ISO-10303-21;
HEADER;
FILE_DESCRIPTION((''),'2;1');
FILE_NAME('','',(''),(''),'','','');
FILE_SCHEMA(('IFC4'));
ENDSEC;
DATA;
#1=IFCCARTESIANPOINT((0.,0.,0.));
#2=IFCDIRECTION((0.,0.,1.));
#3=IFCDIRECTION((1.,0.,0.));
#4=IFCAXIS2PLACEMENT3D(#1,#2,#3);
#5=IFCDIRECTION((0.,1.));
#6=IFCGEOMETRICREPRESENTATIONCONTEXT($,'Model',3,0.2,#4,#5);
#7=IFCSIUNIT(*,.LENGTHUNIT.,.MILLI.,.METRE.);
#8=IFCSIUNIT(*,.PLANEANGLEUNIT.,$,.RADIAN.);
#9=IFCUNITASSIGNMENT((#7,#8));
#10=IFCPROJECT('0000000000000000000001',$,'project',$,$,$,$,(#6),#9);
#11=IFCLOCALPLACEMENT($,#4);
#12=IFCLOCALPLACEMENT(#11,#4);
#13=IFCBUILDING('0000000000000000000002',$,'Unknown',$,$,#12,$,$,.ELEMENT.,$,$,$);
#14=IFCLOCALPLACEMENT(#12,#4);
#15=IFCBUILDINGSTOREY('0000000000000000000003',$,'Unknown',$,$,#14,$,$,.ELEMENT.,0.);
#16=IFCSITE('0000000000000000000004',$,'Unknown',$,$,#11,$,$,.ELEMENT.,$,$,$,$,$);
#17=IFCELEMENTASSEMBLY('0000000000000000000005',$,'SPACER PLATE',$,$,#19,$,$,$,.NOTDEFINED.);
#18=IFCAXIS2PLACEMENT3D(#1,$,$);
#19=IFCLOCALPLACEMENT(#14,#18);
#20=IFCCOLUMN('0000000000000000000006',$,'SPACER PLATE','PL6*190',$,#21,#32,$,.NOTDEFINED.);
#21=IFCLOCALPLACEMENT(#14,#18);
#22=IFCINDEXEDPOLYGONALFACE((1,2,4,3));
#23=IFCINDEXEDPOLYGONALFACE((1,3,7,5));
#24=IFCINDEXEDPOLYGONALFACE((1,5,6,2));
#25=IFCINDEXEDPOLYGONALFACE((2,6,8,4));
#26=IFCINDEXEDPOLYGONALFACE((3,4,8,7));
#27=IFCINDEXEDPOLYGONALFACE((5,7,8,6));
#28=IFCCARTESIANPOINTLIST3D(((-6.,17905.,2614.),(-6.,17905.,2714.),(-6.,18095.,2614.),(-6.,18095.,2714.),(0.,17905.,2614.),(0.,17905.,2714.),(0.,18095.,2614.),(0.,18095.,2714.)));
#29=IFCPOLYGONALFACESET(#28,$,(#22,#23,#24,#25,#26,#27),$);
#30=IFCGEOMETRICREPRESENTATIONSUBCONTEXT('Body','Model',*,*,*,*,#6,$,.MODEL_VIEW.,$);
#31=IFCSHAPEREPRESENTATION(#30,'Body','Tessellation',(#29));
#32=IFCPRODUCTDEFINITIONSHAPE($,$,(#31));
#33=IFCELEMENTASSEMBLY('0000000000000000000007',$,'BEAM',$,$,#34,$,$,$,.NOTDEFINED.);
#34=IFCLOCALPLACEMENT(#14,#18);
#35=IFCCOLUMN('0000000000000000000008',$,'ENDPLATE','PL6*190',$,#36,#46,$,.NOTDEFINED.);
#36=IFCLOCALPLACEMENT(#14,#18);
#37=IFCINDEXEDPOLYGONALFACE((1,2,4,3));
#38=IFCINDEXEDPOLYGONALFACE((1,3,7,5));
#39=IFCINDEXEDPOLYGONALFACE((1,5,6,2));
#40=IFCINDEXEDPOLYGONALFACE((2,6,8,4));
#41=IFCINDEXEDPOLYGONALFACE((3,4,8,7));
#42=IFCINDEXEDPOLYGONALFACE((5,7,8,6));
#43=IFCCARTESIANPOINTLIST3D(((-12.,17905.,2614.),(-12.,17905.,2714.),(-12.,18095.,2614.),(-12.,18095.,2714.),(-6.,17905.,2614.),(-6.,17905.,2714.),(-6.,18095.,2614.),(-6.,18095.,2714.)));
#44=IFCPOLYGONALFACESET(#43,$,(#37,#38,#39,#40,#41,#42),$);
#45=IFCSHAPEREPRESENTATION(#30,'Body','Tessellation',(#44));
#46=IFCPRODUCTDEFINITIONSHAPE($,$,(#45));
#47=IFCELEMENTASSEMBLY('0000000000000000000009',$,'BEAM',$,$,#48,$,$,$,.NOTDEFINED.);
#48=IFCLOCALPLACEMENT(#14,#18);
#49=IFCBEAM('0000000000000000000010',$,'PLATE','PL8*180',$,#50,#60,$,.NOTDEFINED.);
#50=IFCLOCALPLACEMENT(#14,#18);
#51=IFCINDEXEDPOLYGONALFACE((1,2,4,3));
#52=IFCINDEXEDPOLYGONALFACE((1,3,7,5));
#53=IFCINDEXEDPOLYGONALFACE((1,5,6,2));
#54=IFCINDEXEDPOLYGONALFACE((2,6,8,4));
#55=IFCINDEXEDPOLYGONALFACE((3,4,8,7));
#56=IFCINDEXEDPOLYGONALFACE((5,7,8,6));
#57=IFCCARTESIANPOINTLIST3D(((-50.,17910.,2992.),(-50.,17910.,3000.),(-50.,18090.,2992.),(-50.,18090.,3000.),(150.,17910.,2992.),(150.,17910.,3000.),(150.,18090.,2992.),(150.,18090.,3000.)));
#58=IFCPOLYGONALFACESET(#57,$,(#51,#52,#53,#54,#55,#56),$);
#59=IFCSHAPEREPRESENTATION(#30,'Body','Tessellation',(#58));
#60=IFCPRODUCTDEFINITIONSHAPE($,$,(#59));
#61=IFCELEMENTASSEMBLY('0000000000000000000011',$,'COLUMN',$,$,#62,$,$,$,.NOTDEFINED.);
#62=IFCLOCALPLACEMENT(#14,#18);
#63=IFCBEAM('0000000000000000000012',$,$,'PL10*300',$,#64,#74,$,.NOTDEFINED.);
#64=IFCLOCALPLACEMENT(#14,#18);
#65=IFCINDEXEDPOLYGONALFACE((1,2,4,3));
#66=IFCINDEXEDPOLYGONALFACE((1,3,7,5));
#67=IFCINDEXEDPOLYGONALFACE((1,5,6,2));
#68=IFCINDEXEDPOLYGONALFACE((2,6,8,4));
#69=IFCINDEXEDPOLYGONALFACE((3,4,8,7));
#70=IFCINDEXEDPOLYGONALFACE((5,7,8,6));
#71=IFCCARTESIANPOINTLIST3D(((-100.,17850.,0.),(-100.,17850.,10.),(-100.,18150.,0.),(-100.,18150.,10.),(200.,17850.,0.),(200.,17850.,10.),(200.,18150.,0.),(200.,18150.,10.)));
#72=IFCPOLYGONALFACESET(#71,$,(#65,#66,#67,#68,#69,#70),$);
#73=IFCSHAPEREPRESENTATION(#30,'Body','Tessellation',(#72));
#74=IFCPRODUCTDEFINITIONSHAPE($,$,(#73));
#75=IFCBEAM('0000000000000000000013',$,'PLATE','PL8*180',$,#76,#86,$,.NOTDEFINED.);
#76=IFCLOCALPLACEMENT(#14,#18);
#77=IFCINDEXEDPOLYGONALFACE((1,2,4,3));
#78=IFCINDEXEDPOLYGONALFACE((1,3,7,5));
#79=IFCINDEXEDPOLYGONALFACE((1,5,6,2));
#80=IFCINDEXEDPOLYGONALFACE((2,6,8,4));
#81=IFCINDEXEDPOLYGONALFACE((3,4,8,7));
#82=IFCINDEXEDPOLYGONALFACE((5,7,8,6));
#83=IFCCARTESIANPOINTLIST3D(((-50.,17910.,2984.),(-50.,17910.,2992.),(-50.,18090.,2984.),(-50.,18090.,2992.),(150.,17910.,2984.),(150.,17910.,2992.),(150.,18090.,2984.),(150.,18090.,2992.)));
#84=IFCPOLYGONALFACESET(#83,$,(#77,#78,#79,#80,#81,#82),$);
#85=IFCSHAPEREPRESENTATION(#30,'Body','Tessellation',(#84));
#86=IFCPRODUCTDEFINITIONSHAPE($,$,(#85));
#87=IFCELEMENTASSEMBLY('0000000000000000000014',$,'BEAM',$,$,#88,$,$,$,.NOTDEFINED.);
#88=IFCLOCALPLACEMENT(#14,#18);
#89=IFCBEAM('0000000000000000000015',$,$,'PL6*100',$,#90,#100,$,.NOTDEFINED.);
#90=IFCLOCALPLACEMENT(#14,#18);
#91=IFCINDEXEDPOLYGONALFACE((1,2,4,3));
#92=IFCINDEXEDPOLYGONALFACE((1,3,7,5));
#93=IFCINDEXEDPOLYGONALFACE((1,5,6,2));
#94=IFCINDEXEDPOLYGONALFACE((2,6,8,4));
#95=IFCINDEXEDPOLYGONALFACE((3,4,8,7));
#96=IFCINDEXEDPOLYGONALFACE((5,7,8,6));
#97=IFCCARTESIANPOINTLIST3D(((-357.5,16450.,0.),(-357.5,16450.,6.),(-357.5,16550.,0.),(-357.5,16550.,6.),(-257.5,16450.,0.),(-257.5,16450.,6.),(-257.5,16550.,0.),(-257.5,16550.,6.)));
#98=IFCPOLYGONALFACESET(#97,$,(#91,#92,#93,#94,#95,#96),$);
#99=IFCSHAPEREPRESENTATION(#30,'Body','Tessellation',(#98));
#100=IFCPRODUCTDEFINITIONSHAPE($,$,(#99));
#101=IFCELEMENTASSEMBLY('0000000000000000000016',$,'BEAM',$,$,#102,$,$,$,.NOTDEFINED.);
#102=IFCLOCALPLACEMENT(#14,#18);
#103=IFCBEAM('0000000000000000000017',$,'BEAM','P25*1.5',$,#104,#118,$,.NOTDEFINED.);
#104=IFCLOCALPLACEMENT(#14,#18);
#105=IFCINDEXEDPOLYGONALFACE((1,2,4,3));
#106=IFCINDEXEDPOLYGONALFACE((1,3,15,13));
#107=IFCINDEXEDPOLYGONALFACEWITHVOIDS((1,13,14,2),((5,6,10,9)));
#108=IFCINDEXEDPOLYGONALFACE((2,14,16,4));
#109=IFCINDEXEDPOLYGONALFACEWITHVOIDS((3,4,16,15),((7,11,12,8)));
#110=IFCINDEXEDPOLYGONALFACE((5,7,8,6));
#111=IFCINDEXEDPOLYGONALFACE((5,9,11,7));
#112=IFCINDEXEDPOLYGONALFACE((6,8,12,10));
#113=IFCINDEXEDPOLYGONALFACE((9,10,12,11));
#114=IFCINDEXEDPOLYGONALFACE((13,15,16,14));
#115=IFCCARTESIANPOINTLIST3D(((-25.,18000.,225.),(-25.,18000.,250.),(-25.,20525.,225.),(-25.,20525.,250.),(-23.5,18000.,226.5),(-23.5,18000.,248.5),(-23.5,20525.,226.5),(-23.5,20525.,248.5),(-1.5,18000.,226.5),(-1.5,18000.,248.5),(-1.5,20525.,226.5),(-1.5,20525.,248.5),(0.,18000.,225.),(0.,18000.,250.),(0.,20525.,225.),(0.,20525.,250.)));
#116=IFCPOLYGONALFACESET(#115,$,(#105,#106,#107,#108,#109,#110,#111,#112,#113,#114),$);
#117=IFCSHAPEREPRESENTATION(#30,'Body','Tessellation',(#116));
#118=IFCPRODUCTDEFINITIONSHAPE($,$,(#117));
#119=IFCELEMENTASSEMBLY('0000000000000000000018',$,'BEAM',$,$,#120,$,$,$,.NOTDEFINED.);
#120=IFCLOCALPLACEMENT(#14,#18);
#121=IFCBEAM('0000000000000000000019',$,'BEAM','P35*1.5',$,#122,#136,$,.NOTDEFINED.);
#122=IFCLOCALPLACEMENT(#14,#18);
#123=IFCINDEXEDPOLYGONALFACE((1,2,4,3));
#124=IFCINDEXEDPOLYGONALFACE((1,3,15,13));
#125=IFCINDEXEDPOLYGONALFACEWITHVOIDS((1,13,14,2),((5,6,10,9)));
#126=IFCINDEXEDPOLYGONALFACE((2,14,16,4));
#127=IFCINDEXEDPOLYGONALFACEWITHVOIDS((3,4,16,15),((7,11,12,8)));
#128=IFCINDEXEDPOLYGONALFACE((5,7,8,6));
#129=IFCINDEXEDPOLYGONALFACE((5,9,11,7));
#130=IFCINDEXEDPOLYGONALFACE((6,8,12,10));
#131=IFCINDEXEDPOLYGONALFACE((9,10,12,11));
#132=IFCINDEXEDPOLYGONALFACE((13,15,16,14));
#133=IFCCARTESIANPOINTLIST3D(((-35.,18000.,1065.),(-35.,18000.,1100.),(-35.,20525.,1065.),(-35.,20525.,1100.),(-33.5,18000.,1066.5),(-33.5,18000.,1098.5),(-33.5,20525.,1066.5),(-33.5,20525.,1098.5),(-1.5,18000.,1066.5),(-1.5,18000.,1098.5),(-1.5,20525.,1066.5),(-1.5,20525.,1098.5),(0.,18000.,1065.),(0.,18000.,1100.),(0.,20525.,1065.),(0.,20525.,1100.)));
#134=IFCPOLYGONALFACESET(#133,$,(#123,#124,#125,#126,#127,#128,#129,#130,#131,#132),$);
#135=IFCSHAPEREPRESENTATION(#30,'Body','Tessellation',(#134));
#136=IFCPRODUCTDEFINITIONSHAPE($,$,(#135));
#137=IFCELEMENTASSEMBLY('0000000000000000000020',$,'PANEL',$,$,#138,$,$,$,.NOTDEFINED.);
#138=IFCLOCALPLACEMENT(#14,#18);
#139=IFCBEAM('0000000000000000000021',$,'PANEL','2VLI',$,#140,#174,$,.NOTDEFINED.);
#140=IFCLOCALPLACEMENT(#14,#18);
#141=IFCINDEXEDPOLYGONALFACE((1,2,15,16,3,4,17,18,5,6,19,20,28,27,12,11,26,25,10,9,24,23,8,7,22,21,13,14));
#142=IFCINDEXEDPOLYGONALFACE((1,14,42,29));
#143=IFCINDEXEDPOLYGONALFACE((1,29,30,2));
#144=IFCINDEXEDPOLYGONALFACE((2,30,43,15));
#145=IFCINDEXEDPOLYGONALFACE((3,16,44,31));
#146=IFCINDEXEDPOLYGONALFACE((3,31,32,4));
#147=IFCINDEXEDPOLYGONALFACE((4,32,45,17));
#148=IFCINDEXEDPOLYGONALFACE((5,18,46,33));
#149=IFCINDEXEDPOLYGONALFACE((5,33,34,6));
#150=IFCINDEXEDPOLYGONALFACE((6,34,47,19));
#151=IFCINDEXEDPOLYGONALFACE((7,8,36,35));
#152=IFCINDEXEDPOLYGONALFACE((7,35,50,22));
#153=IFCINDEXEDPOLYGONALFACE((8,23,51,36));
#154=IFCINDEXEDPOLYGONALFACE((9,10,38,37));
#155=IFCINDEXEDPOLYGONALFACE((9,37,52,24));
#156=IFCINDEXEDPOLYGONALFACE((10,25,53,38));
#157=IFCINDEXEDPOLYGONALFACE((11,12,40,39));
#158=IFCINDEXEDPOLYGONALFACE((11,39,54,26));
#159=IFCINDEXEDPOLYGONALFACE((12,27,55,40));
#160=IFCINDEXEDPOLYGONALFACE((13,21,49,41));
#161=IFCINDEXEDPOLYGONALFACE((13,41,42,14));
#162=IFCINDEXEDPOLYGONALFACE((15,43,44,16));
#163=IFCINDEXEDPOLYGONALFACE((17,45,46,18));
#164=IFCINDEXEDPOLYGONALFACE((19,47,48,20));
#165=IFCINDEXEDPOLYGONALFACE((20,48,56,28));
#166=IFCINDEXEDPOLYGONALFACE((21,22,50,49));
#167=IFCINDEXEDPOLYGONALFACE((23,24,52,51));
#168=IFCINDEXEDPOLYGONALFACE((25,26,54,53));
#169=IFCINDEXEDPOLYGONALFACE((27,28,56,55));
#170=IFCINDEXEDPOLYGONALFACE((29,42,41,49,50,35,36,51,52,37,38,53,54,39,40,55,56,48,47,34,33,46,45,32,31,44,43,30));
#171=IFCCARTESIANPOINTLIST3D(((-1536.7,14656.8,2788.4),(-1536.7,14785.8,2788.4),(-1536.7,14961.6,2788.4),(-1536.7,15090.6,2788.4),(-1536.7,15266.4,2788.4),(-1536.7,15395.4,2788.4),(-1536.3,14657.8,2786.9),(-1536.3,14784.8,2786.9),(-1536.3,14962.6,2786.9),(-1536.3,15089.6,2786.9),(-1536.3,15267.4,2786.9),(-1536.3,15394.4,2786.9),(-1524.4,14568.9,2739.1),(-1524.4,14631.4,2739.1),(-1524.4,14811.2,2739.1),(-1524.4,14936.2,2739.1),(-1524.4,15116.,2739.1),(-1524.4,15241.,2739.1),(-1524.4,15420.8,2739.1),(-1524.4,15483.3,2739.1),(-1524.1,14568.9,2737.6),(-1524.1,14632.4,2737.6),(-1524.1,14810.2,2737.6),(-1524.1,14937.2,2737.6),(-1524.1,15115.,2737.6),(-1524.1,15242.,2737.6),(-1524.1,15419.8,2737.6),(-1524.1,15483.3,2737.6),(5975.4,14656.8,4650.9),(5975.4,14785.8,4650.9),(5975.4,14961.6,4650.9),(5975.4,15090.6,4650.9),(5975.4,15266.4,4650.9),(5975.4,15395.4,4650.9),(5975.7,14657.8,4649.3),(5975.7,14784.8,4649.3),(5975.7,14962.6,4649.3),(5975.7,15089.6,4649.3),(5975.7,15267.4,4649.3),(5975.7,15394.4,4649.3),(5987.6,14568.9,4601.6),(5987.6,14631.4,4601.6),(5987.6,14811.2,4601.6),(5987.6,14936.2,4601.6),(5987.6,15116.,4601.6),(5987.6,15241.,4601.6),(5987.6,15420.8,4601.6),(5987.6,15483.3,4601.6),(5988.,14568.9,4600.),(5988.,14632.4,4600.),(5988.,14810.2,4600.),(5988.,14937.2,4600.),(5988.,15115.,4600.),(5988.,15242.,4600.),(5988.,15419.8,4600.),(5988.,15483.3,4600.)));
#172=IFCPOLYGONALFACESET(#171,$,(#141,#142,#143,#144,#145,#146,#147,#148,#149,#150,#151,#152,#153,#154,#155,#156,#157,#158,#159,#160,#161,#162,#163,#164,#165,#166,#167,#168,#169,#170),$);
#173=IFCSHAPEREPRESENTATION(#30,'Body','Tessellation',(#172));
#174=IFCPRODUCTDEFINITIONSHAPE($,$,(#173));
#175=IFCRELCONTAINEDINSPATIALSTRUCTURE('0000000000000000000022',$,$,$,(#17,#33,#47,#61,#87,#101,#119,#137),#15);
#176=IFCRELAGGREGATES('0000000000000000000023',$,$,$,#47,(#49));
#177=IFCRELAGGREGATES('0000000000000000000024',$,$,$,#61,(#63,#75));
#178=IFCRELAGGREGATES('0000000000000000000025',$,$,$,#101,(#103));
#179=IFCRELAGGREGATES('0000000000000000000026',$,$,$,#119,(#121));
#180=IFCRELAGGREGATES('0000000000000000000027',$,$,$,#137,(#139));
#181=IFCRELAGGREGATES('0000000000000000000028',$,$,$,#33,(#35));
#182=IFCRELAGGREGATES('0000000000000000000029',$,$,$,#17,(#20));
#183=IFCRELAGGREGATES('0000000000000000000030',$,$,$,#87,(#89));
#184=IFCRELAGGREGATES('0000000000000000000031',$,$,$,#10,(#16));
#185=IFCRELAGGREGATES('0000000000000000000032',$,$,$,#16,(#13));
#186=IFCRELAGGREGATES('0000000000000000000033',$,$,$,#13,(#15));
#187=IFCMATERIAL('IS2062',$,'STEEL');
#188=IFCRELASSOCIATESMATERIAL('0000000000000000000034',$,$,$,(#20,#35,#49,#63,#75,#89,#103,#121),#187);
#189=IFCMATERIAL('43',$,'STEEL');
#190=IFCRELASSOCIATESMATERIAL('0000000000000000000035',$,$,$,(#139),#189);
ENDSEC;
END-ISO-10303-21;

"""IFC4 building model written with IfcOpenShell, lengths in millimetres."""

from ifc_helpers import new_model, si_unit, direction, frame, origin_with_axes, place, context, subcontext, project, spatial, line, indexed_curve, outline, extrude, material, element, aggregate, save


model = new_model("IFC4")

# Units and contexts
model_context = context("Model", 3, precision=0.2, world=origin_with_axes(), true_north=direction((0.0, 1.0)))
body_context = subcontext(model_context, "Body", "Model", "MODEL_VIEW")
ifc_project = project(units=[si_unit("LENGTHUNIT", "METRE", prefix="MILLI"), si_unit("PLANEANGLEUNIT", "RADIAN")], contexts=[model_context])

# Site, building, storey
site_placement = place(None, origin_with_axes())
site = spatial("IfcSite", under=ifc_project, at=site_placement, Name="Unknown", CompositionType="ELEMENT")
building_placement = place(site_placement, origin_with_axes())
building = spatial("IfcBuilding", under=site, at=building_placement, Name="Unknown", CompositionType="ELEMENT")
storey_placement = place(building_placement, origin_with_axes())
storey = spatial("IfcBuildingStorey", under=building, at=storey_placement, Name="Unknown", CompositionType="ELEMENT", Elevation=0.0)

# Element assemblies, columns
assembly_1_placement = place(storey_placement, frame((-3.0, 18000.0, 2614.0), z_axis=(-1.0, 0.0, 0.0), x_axis=(0.0, 0.0, 1.0)))
assembly_1 = element("IfcElementAssembly", 1, at=assembly_1_placement, inside=storey, Name="SPACER PLATE", PredefinedType="NOTDEFINED")
ifc_material_1 = material(Name="IS2062", Category="STEEL")
column_1_placement = place(assembly_1_placement, origin_with_axes())
column_1 = element("IfcColumn", 2, at=column_1_placement, material=ifc_material_1, Name="SPACER PLATE", Description="PL6*190", PredefinedType="NOTDEFINED", context=body_context, shape_type="SolidModel", body=[
    extrude(outline(indexed_curve([(-3.0, -95.0), (3.0, -95.0), (3.0, 95.0), (-3.0, 95.0)], segments=[line(1, 2, 3, 4, 1)])), frame((0.0, 0.0, 0.0), z_axis=(-1.0, 0.0, 0.0), x_axis=(0.0, 0.0, 1.0)), (0.0, 0.0, -1.0), 100.0),
])
assembly_2_placement = place(storey_placement, frame((-1505.9, 18000.0, 2664.0), z_axis=(0.0, -1.0, 0.0), x_axis=(1.0, 0.0, 0.0)))
assembly_2 = element("IfcElementAssembly", 3, at=assembly_2_placement, inside=storey, Name="BEAM", PredefinedType="NOTDEFINED")
column_2_placement = place(assembly_2_placement, frame((1496.9, -50.0, 0.0), z_axis=(-1.0, 0.0, 0.0), x_axis=(0.0, 1.0, 0.0)))
column_2 = element("IfcColumn", 4, at=column_2_placement, material=ifc_material_1, Name="ENDPLATE", Description="PL6*190", PredefinedType="NOTDEFINED", context=body_context, shape_type="SolidModel", body=[
    extrude(outline(indexed_curve([(-3.0, -95.0), (3.0, -95.0), (3.0, 95.0), (-3.0, 95.0)], segments=[line(1, 2, 3, 4, 1)])), frame((0.0, 0.0, 0.0), z_axis=(-1.0, 0.0, 0.0), x_axis=(0.0, 0.0, 1.0)), (0.0, 0.0, -1.0), 100.0),
])

# Element assembly, beam
assembly_3_placement = place(storey_placement, frame((-50.0, 18000.0, 3025.0), z_axis=(0.0, -1.0, 0.0), x_axis=(1.0, 0.0, 0.0)))
assembly_3 = element("IfcElementAssembly", 5, at=assembly_3_placement, inside=storey, Name="BEAM", PredefinedType="NOTDEFINED")
beam_1_placement = place(assembly_3_placement, frame((0.0, -29.0, 0.0), z_axis=(0.0, -1.0, 0.0), x_axis=(1.0, 0.0, 0.0)))
beam_1 = element("IfcBeam", 6, at=beam_1_placement, material=ifc_material_1, Name="PLATE", Description="PL8*180", PredefinedType="NOTDEFINED", context=body_context, shape_type="SolidModel", body=[
    extrude(outline(indexed_curve([(-4.0, -90.0), (4.0, -90.0), (4.0, 90.0), (-4.0, 90.0)], segments=[line(1, 2, 3, 4, 1)])), frame((0.0, 0.0, 0.0), z_axis=(-1.0, 0.0, 0.0), x_axis=(0.0, 0.0, 1.0)), (0.0, 0.0, -1.0), 200.0),
])
aggregate(assembly_3, [beam_1])

# Element assembly, beams
assembly_4_placement = place(storey_placement, frame((50.0, 18000.0, 0.0), z_axis=(0.0, 1.0, 0.0), x_axis=(0.0, 0.0, 1.0)))
assembly_4 = element("IfcElementAssembly", 7, at=assembly_4_placement, inside=storey, Name="COLUMN", PredefinedType="NOTDEFINED")
beam_2_placement = place(assembly_4_placement, frame((5.0, -150.0, 0.0), z_axis=(1.0, 0.0, 0.0), x_axis=(0.0, 1.0, 0.0)))
beam_2 = element("IfcBeam", 8, at=beam_2_placement, material=ifc_material_1, Description="PL10*300", PredefinedType="NOTDEFINED", context=body_context, shape_type="SolidModel", body=[
    extrude(outline(indexed_curve([(-5.0, -150.0), (5.0, -150.0), (5.0, 150.0), (-5.0, 150.0)], segments=[line(1, 2, 3, 4, 1)])), frame((0.0, 0.0, 0.0), z_axis=(-1.0, 0.0, 0.0), x_axis=(0.0, 0.0, 1.0)), (0.0, 0.0, -1.0), 300.0),
])
beam_3_placement = place(assembly_4_placement, frame((2988.0, -100.0, 0.0), z_axis=(-1.0, 0.0, 0.0), x_axis=(0.0, 1.0, 0.0)))
beam_3 = element("IfcBeam", 9, at=beam_3_placement, material=ifc_material_1, Name="PLATE", Description="PL8*180", PredefinedType="NOTDEFINED", context=body_context, shape_type="SolidModel", body=[
    extrude(outline(indexed_curve([(-4.0, -90.0), (4.0, -90.0), (4.0, 90.0), (-4.0, 90.0)], segments=[line(1, 2, 3, 4, 1)])), frame((0.0, 0.0, 0.0), z_axis=(-1.0, 0.0, 0.0), x_axis=(0.0, 0.0, 1.0)), (0.0, 0.0, -1.0), 200.0),
])
aggregate(assembly_4, [beam_2, beam_3])

# Element assemblies, beams
assembly_5_placement = place(storey_placement, frame((-307.5, 16500.0, 700.0), z_axis=(0.0, 1.0, 0.0), x_axis=(0.0, 0.0, -1.0)))
assembly_5 = element("IfcElementAssembly", 10, at=assembly_5_placement, inside=storey, Name="BEAM", PredefinedType="NOTDEFINED")
beam_4_placement = place(assembly_5_placement, frame((697.0, -50.0, 0.0), z_axis=(-1.0, 0.0, 0.0), x_axis=(0.0, 1.0, 0.0)))
beam_4 = element("IfcBeam", 11, at=beam_4_placement, material=ifc_material_1, Description="PL6*100", PredefinedType="NOTDEFINED", context=body_context, shape_type="SolidModel", body=[
    extrude(outline(indexed_curve([(-3.0, -50.0), (3.0, -50.0), (3.0, 50.0), (-3.0, 50.0)], segments=[line(1, 2, 3, 4, 1)])), frame((0.0, 0.0, 0.0), z_axis=(-1.0, 0.0, 0.0), x_axis=(0.0, 0.0, 1.0)), (0.0, 0.0, -1.0), 100.0),
])
assembly_6_placement = place(storey_placement, frame((-12.5, 18000.0, 237.5), z_axis=(1.0, 0.0, 0.0), x_axis=(0.0, 1.0, 0.0)))
assembly_6 = element("IfcElementAssembly", 12, at=assembly_6_placement, inside=storey, Name="BEAM", PredefinedType="NOTDEFINED")
beam_5_placement = place(assembly_6_placement, origin_with_axes())
beam_5 = element("IfcBeam", 13, at=beam_5_placement, material=ifc_material_1, Name="BEAM", Description="P25*1.5", PredefinedType="NOTDEFINED", context=body_context, shape_type="SolidModel", body=[
    extrude(outline(indexed_curve([(-12.5, -12.5), (12.5, -12.5), (12.5, 12.5), (-12.5, 12.5)], segments=[line(1, 2, 3, 4, 1)]), holes=[indexed_curve([(-11.0, -11.0), (-11.0, 11.0), (11.0, 11.0), (11.0, -11.0)], segments=[line(1, 2, 3, 4, 1)])]), frame((0.0, 0.0, 0.0), z_axis=(-1.0, 0.0, 0.0), x_axis=(0.0, 0.0, 1.0)), (0.0, 0.0, -1.0), 2525.0),
])
aggregate(assembly_6, [beam_5])
assembly_7_placement = place(storey_placement, frame((-17.5, 18000.0, 1082.5), z_axis=(1.0, 0.0, 0.0), x_axis=(0.0, 1.0, 0.0)))
assembly_7 = element("IfcElementAssembly", 14, at=assembly_7_placement, inside=storey, Name="BEAM", PredefinedType="NOTDEFINED")
beam_6_placement = place(assembly_7_placement, origin_with_axes())
beam_6 = element("IfcBeam", 15, at=beam_6_placement, material=ifc_material_1, Name="BEAM", Description="P35*1.5", PredefinedType="NOTDEFINED", context=body_context, shape_type="SolidModel", body=[
    extrude(outline(indexed_curve([(-17.5, -17.5), (17.5, -17.5), (17.5, 17.5), (-17.5, 17.5)], segments=[line(1, 2, 3, 4, 1)]), holes=[indexed_curve([(-16.0, -16.0), (-16.0, 16.0), (16.0, 16.0), (16.0, -16.0)], segments=[line(1, 2, 3, 4, 1)])]), frame((0.0, 0.0, 0.0), z_axis=(-1.0, 0.0, 0.0), x_axis=(0.0, 0.0, 1.0)), (0.0, 0.0, -1.0), 2525.0),
])
aggregate(assembly_7, [beam_6])
assembly_8_placement = place(storey_placement, frame((-1530.4, 15026.1, 2763.0), z_axis=(0.0, -1.0, 0.0), x_axis=(0.970613, 0.0, 0.240648)))
assembly_8 = element("IfcElementAssembly", 16, at=assembly_8_placement, inside=storey, Name="PANEL", PredefinedType="NOTDEFINED")
ifc_material_2 = material(Name="43", Category="STEEL")
beam_7_placement = place(assembly_8_placement, origin_with_axes())
beam_7 = element("IfcBeam", 17, at=beam_7_placement, material=ifc_material_2, Name="PANEL", Description="2VLI", PredefinedType="NOTDEFINED", context=body_context, shape_type="SolidModel", body=[
    extrude(outline(indexed_curve([(457.2, -26.2), (457.2, -24.6), (394.7, -24.6), (369.3, 26.2), (240.3, 26.2), (214.9, -24.6), (89.9, -24.6), (64.5, 26.2), (-64.5, 26.2), (-89.9, -24.6), (-214.9, -24.6), (-240.3, 26.2), (-369.3, 26.2), (-394.7, -24.6), (-457.2, -24.6), (-457.2, -26.2), (-393.7, -26.2), (-368.3, 24.6), (-241.3, 24.6), (-215.9, -26.2), (-88.9, -26.2), (-63.5, 24.6), (63.5, 24.6), (88.9, -26.2), (215.9, -26.2), (241.3, 24.6), (368.3, 24.6), (393.7, -26.2)], segments=[line(1, 2, 3, 4, 5, 6, 7, 8, 9, 10, 11, 12, 13, 14, 15, 16, 17, 18, 19, 20, 21, 22, 23, 24, 25, 26, 27, 28, 1)])), frame((0.0, 0.0, 0.0), z_axis=(-1.0, 0.0, 0.0), x_axis=(0.0, 0.0, 1.0)), (0.0, 0.0, -1.0), 7739.5),
])
aggregate(assembly_8, [beam_7])

aggregate(assembly_2, [column_2])

aggregate(assembly_1, [column_1])
aggregate(assembly_5, [beam_4])

save(model, "model.ifc")
